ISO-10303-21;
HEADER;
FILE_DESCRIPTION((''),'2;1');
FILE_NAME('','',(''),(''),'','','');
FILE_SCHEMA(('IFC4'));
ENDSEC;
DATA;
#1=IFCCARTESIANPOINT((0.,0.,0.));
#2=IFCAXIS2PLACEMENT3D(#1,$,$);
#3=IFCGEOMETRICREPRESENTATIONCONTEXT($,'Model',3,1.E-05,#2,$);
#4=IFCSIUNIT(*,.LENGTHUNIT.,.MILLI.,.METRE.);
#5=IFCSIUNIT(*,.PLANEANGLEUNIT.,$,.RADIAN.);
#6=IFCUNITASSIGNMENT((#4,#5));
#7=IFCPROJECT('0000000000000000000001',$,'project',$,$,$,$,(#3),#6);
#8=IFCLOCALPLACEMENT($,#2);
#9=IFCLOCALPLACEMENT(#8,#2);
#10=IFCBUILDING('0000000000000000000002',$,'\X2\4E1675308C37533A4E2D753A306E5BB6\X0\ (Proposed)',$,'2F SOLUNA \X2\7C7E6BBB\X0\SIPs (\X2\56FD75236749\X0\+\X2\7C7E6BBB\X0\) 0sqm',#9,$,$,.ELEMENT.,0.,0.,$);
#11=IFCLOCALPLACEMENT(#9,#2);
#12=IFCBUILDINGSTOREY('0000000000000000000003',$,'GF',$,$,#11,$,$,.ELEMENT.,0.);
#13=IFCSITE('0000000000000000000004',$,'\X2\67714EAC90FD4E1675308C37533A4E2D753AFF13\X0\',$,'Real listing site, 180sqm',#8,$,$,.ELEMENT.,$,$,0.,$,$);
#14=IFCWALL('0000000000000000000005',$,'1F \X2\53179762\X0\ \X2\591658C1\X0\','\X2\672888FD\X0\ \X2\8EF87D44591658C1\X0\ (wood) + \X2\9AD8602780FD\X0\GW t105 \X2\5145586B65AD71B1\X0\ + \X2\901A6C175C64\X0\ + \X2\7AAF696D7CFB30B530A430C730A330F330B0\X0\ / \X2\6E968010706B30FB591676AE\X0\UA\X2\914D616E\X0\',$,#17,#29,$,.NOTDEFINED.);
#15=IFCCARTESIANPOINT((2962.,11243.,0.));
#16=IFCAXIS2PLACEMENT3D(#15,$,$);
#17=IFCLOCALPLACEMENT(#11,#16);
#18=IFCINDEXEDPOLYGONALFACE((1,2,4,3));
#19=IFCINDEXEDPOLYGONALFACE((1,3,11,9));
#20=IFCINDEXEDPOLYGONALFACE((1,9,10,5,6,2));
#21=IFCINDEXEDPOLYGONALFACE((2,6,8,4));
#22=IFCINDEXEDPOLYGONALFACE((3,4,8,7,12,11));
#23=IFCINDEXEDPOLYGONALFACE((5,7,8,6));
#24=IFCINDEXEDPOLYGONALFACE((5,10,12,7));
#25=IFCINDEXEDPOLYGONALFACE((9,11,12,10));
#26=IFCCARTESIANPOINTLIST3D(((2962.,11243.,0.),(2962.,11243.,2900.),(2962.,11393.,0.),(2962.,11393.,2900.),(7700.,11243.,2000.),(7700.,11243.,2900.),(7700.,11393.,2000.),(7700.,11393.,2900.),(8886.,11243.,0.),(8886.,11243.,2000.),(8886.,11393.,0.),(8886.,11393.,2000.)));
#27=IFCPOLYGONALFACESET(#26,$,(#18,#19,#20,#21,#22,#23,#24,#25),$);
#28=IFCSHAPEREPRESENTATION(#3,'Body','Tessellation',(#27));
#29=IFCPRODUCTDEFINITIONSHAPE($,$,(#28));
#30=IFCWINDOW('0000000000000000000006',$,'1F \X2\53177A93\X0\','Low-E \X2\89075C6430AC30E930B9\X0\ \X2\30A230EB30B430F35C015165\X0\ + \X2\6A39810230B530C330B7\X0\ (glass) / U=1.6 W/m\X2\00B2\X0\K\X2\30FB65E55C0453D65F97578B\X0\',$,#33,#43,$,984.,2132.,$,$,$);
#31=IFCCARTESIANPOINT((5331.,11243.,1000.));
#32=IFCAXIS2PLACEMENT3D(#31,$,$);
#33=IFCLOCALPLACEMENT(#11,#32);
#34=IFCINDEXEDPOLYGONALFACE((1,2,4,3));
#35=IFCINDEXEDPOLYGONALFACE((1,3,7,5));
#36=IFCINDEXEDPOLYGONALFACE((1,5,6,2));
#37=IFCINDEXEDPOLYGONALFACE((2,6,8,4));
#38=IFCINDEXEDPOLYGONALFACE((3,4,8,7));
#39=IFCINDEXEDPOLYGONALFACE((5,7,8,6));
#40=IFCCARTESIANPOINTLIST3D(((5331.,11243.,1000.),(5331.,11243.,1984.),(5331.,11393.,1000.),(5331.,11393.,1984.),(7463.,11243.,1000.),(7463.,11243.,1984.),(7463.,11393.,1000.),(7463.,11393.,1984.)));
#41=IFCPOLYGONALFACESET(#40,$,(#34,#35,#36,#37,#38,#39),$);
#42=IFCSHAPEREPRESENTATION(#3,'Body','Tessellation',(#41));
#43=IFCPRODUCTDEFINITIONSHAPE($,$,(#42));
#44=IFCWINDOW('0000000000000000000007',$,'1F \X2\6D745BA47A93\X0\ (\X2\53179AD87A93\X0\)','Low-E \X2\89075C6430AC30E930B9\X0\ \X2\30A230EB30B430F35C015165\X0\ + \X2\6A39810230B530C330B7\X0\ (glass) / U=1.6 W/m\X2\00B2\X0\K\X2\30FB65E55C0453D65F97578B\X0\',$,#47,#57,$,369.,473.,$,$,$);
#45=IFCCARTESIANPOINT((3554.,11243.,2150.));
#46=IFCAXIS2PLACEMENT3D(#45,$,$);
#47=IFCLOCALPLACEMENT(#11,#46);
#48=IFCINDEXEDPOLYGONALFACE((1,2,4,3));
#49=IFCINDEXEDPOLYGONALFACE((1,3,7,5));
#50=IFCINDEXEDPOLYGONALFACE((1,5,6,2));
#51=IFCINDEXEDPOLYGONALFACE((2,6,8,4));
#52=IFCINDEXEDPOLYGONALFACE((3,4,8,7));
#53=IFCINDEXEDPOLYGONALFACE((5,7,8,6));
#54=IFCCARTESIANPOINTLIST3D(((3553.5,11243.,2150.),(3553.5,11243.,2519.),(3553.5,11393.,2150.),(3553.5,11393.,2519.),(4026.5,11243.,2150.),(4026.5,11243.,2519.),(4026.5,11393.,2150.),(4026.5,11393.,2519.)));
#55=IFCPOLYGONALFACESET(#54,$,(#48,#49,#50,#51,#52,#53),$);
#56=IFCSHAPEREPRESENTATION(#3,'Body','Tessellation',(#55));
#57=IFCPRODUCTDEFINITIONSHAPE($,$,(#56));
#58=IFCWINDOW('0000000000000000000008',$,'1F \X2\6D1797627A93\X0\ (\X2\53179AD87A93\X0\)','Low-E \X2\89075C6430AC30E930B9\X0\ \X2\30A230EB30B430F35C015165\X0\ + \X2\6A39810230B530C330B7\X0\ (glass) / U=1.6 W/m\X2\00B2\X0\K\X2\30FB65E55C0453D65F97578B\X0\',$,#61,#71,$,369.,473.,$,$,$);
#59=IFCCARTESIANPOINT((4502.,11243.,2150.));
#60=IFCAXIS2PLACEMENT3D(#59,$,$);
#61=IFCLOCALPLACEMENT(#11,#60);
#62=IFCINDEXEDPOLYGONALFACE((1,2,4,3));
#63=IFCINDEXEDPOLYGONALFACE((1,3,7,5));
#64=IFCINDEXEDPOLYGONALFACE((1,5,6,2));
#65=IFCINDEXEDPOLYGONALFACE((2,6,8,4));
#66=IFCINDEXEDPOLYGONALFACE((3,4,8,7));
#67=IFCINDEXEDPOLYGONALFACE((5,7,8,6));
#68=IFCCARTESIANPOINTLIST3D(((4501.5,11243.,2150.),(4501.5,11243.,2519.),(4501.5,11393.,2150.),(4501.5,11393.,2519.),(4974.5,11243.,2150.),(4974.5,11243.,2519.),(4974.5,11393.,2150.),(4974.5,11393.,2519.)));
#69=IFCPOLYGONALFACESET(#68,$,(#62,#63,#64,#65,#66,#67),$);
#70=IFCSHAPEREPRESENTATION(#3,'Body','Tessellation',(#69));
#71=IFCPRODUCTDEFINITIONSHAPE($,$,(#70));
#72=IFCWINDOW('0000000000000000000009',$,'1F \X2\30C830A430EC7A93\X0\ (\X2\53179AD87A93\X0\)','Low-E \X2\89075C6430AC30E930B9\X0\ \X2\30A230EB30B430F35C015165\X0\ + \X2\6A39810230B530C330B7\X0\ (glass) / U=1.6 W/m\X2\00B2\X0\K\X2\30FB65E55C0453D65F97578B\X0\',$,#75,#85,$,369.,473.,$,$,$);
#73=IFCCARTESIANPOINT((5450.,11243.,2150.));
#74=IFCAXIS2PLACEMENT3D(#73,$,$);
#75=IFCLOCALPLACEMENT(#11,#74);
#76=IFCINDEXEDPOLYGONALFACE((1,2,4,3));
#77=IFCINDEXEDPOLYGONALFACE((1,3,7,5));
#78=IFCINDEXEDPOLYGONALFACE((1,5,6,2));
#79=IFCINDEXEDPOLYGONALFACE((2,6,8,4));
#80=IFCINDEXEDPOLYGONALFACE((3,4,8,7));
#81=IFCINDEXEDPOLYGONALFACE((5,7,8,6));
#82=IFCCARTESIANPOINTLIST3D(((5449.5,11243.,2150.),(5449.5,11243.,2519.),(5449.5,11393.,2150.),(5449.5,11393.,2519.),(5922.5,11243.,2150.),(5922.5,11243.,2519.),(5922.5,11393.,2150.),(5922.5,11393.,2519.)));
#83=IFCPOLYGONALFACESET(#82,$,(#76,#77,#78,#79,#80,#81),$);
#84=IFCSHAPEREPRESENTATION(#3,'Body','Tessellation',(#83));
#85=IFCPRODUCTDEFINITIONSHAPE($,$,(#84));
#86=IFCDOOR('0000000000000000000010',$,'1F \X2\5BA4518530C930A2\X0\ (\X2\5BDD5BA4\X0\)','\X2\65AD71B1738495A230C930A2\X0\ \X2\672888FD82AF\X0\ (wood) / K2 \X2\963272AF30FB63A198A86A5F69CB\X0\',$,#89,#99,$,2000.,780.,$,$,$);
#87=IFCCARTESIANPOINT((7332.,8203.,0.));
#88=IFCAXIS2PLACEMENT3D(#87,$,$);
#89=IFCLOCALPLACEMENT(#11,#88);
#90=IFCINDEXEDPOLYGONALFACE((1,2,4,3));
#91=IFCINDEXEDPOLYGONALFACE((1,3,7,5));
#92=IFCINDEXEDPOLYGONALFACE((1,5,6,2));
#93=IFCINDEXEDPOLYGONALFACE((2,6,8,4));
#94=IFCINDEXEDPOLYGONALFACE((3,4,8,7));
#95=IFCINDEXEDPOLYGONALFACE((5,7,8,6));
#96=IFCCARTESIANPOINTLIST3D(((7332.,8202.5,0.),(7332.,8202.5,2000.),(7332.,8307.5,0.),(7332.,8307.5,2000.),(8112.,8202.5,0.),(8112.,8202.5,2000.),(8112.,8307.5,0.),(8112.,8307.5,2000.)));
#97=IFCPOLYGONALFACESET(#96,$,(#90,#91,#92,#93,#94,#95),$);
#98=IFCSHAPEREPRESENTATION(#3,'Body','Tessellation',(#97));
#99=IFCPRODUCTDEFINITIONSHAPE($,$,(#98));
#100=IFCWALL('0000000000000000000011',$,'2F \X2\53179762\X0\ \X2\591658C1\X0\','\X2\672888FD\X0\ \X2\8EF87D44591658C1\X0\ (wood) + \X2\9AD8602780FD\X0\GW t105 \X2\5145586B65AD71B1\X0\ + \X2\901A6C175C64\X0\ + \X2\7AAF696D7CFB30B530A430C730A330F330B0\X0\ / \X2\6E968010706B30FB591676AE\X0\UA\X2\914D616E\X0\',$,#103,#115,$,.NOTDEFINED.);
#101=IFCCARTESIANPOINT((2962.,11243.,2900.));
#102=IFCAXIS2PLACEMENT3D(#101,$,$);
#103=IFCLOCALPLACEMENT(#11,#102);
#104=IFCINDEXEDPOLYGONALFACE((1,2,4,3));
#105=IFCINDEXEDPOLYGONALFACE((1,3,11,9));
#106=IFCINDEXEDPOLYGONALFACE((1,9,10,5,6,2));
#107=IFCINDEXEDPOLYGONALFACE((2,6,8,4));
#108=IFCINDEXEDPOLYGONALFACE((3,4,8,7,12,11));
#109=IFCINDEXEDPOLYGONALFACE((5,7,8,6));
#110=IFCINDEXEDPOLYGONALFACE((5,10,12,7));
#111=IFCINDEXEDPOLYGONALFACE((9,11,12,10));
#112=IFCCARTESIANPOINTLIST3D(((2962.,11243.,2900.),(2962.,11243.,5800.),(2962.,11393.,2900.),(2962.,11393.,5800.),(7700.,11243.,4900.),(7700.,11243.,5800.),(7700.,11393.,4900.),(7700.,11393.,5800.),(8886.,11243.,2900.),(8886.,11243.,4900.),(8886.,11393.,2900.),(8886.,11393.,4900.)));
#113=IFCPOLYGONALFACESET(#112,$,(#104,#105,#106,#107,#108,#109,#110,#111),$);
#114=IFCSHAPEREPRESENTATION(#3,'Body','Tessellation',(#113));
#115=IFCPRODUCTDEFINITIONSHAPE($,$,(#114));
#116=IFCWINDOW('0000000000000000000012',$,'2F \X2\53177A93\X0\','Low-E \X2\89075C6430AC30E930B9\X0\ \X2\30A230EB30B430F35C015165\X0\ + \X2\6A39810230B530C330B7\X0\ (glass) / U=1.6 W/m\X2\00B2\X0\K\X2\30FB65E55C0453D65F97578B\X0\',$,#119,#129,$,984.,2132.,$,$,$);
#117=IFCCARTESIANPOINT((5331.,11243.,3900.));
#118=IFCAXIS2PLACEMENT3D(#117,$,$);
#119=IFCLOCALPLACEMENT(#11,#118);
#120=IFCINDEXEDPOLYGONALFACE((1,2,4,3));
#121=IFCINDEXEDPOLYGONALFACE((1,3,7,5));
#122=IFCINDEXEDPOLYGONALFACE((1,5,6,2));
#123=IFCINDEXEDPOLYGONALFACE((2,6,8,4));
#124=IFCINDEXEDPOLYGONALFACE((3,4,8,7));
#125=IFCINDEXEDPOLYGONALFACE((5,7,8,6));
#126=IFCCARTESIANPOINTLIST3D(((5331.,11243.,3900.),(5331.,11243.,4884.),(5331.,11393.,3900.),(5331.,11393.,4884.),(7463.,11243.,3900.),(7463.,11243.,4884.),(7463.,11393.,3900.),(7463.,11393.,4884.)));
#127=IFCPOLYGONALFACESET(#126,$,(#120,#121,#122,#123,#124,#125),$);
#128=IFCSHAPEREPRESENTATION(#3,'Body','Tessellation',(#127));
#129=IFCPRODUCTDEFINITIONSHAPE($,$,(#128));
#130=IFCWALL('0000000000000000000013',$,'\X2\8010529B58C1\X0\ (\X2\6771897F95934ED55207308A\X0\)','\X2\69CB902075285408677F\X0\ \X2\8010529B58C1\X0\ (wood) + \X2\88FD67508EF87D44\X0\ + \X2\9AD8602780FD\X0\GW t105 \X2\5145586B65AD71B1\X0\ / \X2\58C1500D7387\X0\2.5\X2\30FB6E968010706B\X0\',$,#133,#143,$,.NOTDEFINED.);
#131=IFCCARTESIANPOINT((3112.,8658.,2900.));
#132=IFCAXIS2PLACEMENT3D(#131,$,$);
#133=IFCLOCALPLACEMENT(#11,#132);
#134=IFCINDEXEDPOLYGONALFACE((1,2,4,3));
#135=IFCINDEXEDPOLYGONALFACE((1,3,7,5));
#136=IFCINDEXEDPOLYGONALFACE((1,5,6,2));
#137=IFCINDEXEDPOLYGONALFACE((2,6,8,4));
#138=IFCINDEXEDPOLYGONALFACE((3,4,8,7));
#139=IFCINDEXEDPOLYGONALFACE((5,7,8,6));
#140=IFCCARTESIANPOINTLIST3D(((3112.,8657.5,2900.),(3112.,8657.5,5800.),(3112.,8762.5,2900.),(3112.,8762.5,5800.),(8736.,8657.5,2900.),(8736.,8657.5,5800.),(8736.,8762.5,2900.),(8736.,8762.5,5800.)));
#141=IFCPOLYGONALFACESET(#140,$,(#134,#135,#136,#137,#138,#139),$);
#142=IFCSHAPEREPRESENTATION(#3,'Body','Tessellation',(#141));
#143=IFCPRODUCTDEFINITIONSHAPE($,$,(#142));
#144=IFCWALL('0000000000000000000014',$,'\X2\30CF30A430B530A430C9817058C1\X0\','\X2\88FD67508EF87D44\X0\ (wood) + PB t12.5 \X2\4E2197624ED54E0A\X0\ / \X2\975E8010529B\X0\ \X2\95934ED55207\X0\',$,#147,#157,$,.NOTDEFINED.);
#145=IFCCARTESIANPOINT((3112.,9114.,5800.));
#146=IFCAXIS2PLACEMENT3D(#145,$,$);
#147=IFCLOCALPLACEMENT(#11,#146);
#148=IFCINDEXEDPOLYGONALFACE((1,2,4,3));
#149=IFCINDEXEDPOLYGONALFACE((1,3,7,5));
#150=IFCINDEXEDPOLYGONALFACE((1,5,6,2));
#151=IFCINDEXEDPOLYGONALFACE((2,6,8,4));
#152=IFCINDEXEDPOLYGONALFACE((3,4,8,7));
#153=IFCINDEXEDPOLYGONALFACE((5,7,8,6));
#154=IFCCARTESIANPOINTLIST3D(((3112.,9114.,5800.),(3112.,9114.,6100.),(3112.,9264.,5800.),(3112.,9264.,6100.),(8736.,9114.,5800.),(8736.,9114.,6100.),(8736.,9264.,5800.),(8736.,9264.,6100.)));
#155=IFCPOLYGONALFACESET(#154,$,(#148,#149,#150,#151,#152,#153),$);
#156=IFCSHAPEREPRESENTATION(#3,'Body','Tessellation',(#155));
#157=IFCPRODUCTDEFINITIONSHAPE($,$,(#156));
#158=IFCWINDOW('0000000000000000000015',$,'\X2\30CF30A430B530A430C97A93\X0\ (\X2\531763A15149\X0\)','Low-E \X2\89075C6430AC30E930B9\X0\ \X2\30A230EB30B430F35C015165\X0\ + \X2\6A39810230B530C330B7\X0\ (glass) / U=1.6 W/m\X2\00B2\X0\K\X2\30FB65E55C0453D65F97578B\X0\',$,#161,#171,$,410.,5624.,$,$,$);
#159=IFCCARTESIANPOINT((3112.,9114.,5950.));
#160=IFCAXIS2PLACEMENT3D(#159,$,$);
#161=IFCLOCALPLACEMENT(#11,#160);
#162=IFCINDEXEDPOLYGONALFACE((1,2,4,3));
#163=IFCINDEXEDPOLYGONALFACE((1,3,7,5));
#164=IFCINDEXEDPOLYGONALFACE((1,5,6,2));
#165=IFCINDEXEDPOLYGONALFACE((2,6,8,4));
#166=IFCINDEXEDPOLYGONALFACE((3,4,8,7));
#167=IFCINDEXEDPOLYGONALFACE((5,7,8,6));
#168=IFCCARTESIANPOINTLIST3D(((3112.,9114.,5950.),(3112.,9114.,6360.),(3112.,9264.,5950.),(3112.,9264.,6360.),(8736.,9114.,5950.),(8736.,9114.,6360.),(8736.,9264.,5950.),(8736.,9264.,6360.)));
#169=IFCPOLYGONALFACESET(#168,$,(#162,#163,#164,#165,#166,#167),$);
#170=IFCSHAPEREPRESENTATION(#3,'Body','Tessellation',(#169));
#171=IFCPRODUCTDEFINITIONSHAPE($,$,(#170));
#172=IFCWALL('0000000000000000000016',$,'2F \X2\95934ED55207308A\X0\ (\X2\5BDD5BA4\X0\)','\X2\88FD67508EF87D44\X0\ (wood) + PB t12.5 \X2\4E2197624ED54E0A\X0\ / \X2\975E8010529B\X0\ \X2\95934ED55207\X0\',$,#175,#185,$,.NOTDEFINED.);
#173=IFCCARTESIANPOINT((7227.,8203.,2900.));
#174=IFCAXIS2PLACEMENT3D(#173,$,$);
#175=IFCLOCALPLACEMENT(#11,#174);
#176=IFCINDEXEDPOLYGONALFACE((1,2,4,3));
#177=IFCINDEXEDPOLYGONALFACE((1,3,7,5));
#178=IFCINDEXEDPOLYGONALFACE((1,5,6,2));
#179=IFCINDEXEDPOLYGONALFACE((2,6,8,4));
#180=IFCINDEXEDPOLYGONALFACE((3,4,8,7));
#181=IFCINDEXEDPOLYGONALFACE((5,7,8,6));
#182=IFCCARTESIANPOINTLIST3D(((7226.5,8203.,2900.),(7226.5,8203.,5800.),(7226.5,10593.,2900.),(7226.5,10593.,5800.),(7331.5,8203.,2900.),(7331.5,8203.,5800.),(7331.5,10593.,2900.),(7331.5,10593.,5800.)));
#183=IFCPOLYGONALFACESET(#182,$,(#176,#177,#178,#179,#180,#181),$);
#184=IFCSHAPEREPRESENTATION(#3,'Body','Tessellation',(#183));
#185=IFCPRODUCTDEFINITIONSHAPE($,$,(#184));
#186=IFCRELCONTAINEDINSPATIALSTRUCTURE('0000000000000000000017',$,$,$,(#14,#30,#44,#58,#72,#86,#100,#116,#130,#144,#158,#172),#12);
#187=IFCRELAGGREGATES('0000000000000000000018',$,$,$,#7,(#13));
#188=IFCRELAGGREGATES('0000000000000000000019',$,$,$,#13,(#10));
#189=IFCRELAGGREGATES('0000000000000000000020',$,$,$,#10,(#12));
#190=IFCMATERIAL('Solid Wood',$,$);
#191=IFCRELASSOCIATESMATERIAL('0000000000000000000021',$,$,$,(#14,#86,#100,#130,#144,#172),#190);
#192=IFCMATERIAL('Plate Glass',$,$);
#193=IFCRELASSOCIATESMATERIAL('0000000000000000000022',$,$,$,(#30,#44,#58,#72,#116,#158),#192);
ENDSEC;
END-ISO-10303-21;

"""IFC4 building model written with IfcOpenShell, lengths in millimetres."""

from ifc_helpers import new_model, si_unit, frame, frame_2d, origin, place, context, project, spatial, rectangle, extrude, material, element, fill, save


model = new_model("IFC4")

# Units and contexts
model_context = context("Model", 3, precision=1e-05, world=origin())
ifc_project = project(units=[si_unit("LENGTHUNIT", "METRE", prefix="MILLI"), si_unit("PLANEANGLEUNIT", "RADIAN")], contexts=[model_context])

# Site, building, storey
site_placement = place(None, origin())
site = spatial("IfcSite", under=ifc_project, at=site_placement, Name="東京都世田谷区中町３", ObjectType="Real listing site, 180sqm", CompositionType="ELEMENT", RefElevation=0.0)
building_placement = place(site_placement, origin())
building = spatial("IfcBuilding", under=site, at=building_placement, Name="世田谷区中町の家 (Proposed)", ObjectType="2F SOLUNA 籾殻SIPs (国産杉+籾殻) 0sqm", CompositionType="ELEMENT", ElevationOfRefHeight=0.0, ElevationOfTerrain=0.0)
storey_placement = place(building_placement, origin())
storey = spatial("IfcBuildingStorey", under=building, at=storey_placement, Name="GF", CompositionType="ELEMENT", Elevation=0.0)

# Wall, openings, windows
ifc_material_1 = material(Name="Solid Wood")
wall_1_placement = place(storey_placement, frame((2962.0, 11243.0, 0.0)))
wall_1 = element("IfcWall", 1, at=wall_1_placement, inside=storey, material=ifc_material_1, Name="1F 北面 外壁", Description="木製 軸組外壁 (wood) + 高性能GW t105 充填断熱 + 通気層 + 窯業系サイディング / 準耐火・外皮UA配慮", PredefinedType="NOTDEFINED", context=model_context, shape_type="SweptSolid", body=[
    extrude(rectangle(XDim=5924.0, YDim=150.0, at=frame_2d((2962.0, 75.0))), frame((2962.0, 11243.0, 0.0)), (0.0, 0.0, 1.0), 2900.0),
])
opening_1_placement = place(storey_placement, frame((5331.0, 11243.0, 1000.0)))
opening_1 = element("IfcOpeningElement", 2, at=opening_1_placement, cuts=wall_1, PredefinedType="NOTDEFINED", context=model_context, shape_type="SweptSolid", body=[
    extrude(rectangle(XDim=2132.0, YDim=150.0, at=frame_2d((1066.0, 75.0))), frame((5331.0, 11243.0, 1000.0)), (0.0, 0.0, 1.0), 984.0),
])
opening_2_placement = place(storey_placement, frame((3554.0, 11243.0, 2150.0)))
opening_2 = element("IfcOpeningElement", 3, at=opening_2_placement, cuts=wall_1, PredefinedType="NOTDEFINED", context=model_context, shape_type="SweptSolid", body=[
    extrude(rectangle(XDim=473.0, YDim=150.0, at=frame_2d((236.0, 75.0))), frame((3554.0, 11243.0, 2150.0)), (0.0, 0.0, 1.0), 369.0),
])
opening_3_placement = place(storey_placement, frame((4502.0, 11243.0, 2150.0)))
opening_3 = element("IfcOpeningElement", 4, at=opening_3_placement, cuts=wall_1, PredefinedType="NOTDEFINED", context=model_context, shape_type="SweptSolid", body=[
    extrude(rectangle(XDim=473.0, YDim=150.0, at=frame_2d((236.0, 75.0))), frame((4502.0, 11243.0, 2150.0)), (0.0, 0.0, 1.0), 369.0),
])
opening_4_placement = place(storey_placement, frame((5450.0, 11243.0, 2150.0)))
opening_4 = element("IfcOpeningElement", 5, at=opening_4_placement, cuts=wall_1, PredefinedType="NOTDEFINED", context=model_context, shape_type="SweptSolid", body=[
    extrude(rectangle(XDim=473.0, YDim=150.0, at=frame_2d((236.0, 75.0))), frame((5450.0, 11243.0, 2150.0)), (0.0, 0.0, 1.0), 369.0),
])
ifc_material_2 = material(Name="Plate Glass")
window_1_placement = place(storey_placement, frame((5331.0, 11243.0, 1000.0)))
window_1 = element("IfcWindow", 6, at=window_1_placement, inside=storey, material=ifc_material_2, Name="1F 北窓", Description="Low-E 複層ガラス アルゴン封入 + 樹脂サッシ (glass) / U=1.6 W/m²K・日射取得型", OverallHeight=984.0, OverallWidth=2132.0, context=model_context, shape_type="SweptSolid", body=[
    extrude(rectangle(XDim=2132.0, YDim=150.0, at=frame_2d((1066.0, 75.0))), frame((5331.0, 11243.0, 1000.0)), (0.0, 0.0, 1.0), 984.0),
])
fill(opening_1, window_1)
window_2_placement = place(storey_placement, frame((3554.0, 11243.0, 2150.0)))
window_2 = element("IfcWindow", 7, at=window_2_placement, inside=storey, material=ifc_material_2, Name="1F 浴室窓 (北高窓)", Description="Low-E 複層ガラス アルゴン封入 + 樹脂サッシ (glass) / U=1.6 W/m²K・日射取得型", OverallHeight=369.0, OverallWidth=473.0, context=model_context, shape_type="SweptSolid", body=[
    extrude(rectangle(XDim=473.0, YDim=150.0, at=frame_2d((236.0, 75.0))), frame((3554.0, 11243.0, 2150.0)), (0.0, 0.0, 1.0), 369.0),
])
fill(opening_2, window_2)
window_3_placement = place(storey_placement, frame((4502.0, 11243.0, 2150.0)))
window_3 = element("IfcWindow", 8, at=window_3_placement, inside=storey, material=ifc_material_2, Name="1F 洗面窓 (北高窓)", Description="Low-E 複層ガラス アルゴン封入 + 樹脂サッシ (glass) / U=1.6 W/m²K・日射取得型", OverallHeight=369.0, OverallWidth=473.0, context=model_context, shape_type="SweptSolid", body=[
    extrude(rectangle(XDim=473.0, YDim=150.0, at=frame_2d((236.0, 75.0))), frame((4502.0, 11243.0, 2150.0)), (0.0, 0.0, 1.0), 369.0),
])
fill(opening_3, window_3)
window_4_placement = place(storey_placement, frame((5450.0, 11243.0, 2150.0)))
window_4 = element("IfcWindow", 9, at=window_4_placement, inside=storey, material=ifc_material_2, Name="1F トイレ窓 (北高窓)", Description="Low-E 複層ガラス アルゴン封入 + 樹脂サッシ (glass) / U=1.6 W/m²K・日射取得型", OverallHeight=369.0, OverallWidth=473.0, context=model_context, shape_type="SweptSolid", body=[
    extrude(rectangle(XDim=473.0, YDim=150.0, at=frame_2d((236.0, 75.0))), frame((5450.0, 11243.0, 2150.0)), (0.0, 0.0, 1.0), 369.0),
])
fill(opening_4, window_4)

# Door
door_1_placement = place(storey_placement, frame((7332.0, 8203.0, 0.0)))
element("IfcDoor", 10, at=door_1_placement, inside=storey, material=ifc_material_1, Name="1F 室内ドア (寝室)", Description="断熱玄関ドア 木製芯 (wood) / K2 防犯・採風機構", OverallHeight=2000.0, OverallWidth=780.0, context=model_context, shape_type="SweptSolid", body=[
    extrude(rectangle(XDim=780.0, YDim=105.0, at=frame_2d((390.0, 52.0))), frame((7332.0, 8203.0, 0.0)), (0.0, 0.0, 1.0), 2000.0),
])

# Wall, opening, window
wall_2_placement = place(storey_placement, frame((2962.0, 11243.0, 2900.0)))
wall_2 = element("IfcWall", 11, at=wall_2_placement, inside=storey, material=ifc_material_1, Name="2F 北面 外壁", Description="木製 軸組外壁 (wood) + 高性能GW t105 充填断熱 + 通気層 + 窯業系サイディング / 準耐火・外皮UA配慮", PredefinedType="NOTDEFINED", context=model_context, shape_type="SweptSolid", body=[
    extrude(rectangle(XDim=5924.0, YDim=150.0, at=frame_2d((2962.0, 75.0))), frame((2962.0, 11243.0, 2900.0)), (0.0, 0.0, 1.0), 2900.0),
])
opening_5_placement = place(storey_placement, frame((5331.0, 11243.0, 3900.0)))
opening_5 = element("IfcOpeningElement", 12, at=opening_5_placement, cuts=wall_2, PredefinedType="NOTDEFINED", context=model_context, shape_type="SweptSolid", body=[
    extrude(rectangle(XDim=2132.0, YDim=150.0, at=frame_2d((1066.0, 75.0))), frame((5331.0, 11243.0, 3900.0)), (0.0, 0.0, 1.0), 984.0),
])
window_5_placement = place(storey_placement, frame((5331.0, 11243.0, 3900.0)))
window_5 = element("IfcWindow", 13, at=window_5_placement, inside=storey, material=ifc_material_2, Name="2F 北窓", Description="Low-E 複層ガラス アルゴン封入 + 樹脂サッシ (glass) / U=1.6 W/m²K・日射取得型", OverallHeight=984.0, OverallWidth=2132.0, context=model_context, shape_type="SweptSolid", body=[
    extrude(rectangle(XDim=2132.0, YDim=150.0, at=frame_2d((1066.0, 75.0))), frame((5331.0, 11243.0, 3900.0)), (0.0, 0.0, 1.0), 984.0),
])
fill(opening_5, window_5)

# Wall
wall_3_placement = place(storey_placement, frame((3112.0, 8658.0, 2900.0)))
element("IfcWall", 14, at=wall_3_placement, inside=storey, material=ifc_material_1, Name="耐力壁 (東西間仕切り)", Description="構造用合板 耐力壁 (wood) + 製材軸組 + 高性能GW t105 充填断熱 / 壁倍率2.5・準耐火", PredefinedType="NOTDEFINED", context=model_context, shape_type="SweptSolid", body=[
    extrude(rectangle(XDim=5624.0, YDim=105.0, at=frame_2d((2812.0, 52.0))), frame((3112.0, 8658.0, 2900.0)), (0.0, 0.0, 1.0), 2900.0),
])

# Wall, opening, window
wall_4_placement = place(storey_placement, frame((3112.0, 9114.0, 5800.0)))
wall_4 = element("IfcWall", 15, at=wall_4_placement, inside=storey, material=ifc_material_1, Name="ハイサイド腰壁", Description="製材軸組 (wood) + PB t12.5 両面仕上 / 非耐力 間仕切", PredefinedType="NOTDEFINED", context=model_context, shape_type="SweptSolid", body=[
    extrude(rectangle(XDim=5624.0, YDim=150.0, at=frame_2d((2812.0, 75.0))), frame((3112.0, 9114.0, 5800.0)), (0.0, 0.0, 1.0), 700.0),
])
opening_6_placement = place(storey_placement, frame((3112.0, 9114.0, 5950.0)))
opening_6 = element("IfcOpeningElement", 16, at=opening_6_placement, cuts=wall_4, PredefinedType="NOTDEFINED", context=model_context, shape_type="SweptSolid", body=[
    extrude(rectangle(XDim=5624.0, YDim=150.0, at=frame_2d((2812.0, 75.0))), frame((3112.0, 9114.0, 5950.0)), (0.0, 0.0, 1.0), 410.0),
])
window_6_placement = place(storey_placement, frame((3112.0, 9114.0, 5950.0)))
window_6 = element("IfcWindow", 17, at=window_6_placement, inside=storey, material=ifc_material_2, Name="ハイサイド窓 (北採光)", Description="Low-E 複層ガラス アルゴン封入 + 樹脂サッシ (glass) / U=1.6 W/m²K・日射取得型", OverallHeight=410.0, OverallWidth=5624.0, context=model_context, shape_type="SweptSolid", body=[
    extrude(rectangle(XDim=5624.0, YDim=150.0, at=frame_2d((2812.0, 75.0))), frame((3112.0, 9114.0, 5950.0)), (0.0, 0.0, 1.0), 410.0),
])
fill(opening_6, window_6)

# Wall
wall_5_placement = place(storey_placement, frame((7227.0, 8203.0, 2900.0)))
element("IfcWall", 18, at=wall_5_placement, inside=storey, material=ifc_material_1, Name="2F 間仕切り (寝室)", Description="製材軸組 (wood) + PB t12.5 両面仕上 / 非耐力 間仕切", PredefinedType="NOTDEFINED", context=model_context, shape_type="SweptSolid", body=[
    extrude(rectangle(XDim=105.0, YDim=2390.0, at=frame_2d((52.0, 1195.0))), frame((7227.0, 8203.0, 2900.0)), (0.0, 0.0, 1.0), 2900.0),
])

save(model, "model.ifc")
